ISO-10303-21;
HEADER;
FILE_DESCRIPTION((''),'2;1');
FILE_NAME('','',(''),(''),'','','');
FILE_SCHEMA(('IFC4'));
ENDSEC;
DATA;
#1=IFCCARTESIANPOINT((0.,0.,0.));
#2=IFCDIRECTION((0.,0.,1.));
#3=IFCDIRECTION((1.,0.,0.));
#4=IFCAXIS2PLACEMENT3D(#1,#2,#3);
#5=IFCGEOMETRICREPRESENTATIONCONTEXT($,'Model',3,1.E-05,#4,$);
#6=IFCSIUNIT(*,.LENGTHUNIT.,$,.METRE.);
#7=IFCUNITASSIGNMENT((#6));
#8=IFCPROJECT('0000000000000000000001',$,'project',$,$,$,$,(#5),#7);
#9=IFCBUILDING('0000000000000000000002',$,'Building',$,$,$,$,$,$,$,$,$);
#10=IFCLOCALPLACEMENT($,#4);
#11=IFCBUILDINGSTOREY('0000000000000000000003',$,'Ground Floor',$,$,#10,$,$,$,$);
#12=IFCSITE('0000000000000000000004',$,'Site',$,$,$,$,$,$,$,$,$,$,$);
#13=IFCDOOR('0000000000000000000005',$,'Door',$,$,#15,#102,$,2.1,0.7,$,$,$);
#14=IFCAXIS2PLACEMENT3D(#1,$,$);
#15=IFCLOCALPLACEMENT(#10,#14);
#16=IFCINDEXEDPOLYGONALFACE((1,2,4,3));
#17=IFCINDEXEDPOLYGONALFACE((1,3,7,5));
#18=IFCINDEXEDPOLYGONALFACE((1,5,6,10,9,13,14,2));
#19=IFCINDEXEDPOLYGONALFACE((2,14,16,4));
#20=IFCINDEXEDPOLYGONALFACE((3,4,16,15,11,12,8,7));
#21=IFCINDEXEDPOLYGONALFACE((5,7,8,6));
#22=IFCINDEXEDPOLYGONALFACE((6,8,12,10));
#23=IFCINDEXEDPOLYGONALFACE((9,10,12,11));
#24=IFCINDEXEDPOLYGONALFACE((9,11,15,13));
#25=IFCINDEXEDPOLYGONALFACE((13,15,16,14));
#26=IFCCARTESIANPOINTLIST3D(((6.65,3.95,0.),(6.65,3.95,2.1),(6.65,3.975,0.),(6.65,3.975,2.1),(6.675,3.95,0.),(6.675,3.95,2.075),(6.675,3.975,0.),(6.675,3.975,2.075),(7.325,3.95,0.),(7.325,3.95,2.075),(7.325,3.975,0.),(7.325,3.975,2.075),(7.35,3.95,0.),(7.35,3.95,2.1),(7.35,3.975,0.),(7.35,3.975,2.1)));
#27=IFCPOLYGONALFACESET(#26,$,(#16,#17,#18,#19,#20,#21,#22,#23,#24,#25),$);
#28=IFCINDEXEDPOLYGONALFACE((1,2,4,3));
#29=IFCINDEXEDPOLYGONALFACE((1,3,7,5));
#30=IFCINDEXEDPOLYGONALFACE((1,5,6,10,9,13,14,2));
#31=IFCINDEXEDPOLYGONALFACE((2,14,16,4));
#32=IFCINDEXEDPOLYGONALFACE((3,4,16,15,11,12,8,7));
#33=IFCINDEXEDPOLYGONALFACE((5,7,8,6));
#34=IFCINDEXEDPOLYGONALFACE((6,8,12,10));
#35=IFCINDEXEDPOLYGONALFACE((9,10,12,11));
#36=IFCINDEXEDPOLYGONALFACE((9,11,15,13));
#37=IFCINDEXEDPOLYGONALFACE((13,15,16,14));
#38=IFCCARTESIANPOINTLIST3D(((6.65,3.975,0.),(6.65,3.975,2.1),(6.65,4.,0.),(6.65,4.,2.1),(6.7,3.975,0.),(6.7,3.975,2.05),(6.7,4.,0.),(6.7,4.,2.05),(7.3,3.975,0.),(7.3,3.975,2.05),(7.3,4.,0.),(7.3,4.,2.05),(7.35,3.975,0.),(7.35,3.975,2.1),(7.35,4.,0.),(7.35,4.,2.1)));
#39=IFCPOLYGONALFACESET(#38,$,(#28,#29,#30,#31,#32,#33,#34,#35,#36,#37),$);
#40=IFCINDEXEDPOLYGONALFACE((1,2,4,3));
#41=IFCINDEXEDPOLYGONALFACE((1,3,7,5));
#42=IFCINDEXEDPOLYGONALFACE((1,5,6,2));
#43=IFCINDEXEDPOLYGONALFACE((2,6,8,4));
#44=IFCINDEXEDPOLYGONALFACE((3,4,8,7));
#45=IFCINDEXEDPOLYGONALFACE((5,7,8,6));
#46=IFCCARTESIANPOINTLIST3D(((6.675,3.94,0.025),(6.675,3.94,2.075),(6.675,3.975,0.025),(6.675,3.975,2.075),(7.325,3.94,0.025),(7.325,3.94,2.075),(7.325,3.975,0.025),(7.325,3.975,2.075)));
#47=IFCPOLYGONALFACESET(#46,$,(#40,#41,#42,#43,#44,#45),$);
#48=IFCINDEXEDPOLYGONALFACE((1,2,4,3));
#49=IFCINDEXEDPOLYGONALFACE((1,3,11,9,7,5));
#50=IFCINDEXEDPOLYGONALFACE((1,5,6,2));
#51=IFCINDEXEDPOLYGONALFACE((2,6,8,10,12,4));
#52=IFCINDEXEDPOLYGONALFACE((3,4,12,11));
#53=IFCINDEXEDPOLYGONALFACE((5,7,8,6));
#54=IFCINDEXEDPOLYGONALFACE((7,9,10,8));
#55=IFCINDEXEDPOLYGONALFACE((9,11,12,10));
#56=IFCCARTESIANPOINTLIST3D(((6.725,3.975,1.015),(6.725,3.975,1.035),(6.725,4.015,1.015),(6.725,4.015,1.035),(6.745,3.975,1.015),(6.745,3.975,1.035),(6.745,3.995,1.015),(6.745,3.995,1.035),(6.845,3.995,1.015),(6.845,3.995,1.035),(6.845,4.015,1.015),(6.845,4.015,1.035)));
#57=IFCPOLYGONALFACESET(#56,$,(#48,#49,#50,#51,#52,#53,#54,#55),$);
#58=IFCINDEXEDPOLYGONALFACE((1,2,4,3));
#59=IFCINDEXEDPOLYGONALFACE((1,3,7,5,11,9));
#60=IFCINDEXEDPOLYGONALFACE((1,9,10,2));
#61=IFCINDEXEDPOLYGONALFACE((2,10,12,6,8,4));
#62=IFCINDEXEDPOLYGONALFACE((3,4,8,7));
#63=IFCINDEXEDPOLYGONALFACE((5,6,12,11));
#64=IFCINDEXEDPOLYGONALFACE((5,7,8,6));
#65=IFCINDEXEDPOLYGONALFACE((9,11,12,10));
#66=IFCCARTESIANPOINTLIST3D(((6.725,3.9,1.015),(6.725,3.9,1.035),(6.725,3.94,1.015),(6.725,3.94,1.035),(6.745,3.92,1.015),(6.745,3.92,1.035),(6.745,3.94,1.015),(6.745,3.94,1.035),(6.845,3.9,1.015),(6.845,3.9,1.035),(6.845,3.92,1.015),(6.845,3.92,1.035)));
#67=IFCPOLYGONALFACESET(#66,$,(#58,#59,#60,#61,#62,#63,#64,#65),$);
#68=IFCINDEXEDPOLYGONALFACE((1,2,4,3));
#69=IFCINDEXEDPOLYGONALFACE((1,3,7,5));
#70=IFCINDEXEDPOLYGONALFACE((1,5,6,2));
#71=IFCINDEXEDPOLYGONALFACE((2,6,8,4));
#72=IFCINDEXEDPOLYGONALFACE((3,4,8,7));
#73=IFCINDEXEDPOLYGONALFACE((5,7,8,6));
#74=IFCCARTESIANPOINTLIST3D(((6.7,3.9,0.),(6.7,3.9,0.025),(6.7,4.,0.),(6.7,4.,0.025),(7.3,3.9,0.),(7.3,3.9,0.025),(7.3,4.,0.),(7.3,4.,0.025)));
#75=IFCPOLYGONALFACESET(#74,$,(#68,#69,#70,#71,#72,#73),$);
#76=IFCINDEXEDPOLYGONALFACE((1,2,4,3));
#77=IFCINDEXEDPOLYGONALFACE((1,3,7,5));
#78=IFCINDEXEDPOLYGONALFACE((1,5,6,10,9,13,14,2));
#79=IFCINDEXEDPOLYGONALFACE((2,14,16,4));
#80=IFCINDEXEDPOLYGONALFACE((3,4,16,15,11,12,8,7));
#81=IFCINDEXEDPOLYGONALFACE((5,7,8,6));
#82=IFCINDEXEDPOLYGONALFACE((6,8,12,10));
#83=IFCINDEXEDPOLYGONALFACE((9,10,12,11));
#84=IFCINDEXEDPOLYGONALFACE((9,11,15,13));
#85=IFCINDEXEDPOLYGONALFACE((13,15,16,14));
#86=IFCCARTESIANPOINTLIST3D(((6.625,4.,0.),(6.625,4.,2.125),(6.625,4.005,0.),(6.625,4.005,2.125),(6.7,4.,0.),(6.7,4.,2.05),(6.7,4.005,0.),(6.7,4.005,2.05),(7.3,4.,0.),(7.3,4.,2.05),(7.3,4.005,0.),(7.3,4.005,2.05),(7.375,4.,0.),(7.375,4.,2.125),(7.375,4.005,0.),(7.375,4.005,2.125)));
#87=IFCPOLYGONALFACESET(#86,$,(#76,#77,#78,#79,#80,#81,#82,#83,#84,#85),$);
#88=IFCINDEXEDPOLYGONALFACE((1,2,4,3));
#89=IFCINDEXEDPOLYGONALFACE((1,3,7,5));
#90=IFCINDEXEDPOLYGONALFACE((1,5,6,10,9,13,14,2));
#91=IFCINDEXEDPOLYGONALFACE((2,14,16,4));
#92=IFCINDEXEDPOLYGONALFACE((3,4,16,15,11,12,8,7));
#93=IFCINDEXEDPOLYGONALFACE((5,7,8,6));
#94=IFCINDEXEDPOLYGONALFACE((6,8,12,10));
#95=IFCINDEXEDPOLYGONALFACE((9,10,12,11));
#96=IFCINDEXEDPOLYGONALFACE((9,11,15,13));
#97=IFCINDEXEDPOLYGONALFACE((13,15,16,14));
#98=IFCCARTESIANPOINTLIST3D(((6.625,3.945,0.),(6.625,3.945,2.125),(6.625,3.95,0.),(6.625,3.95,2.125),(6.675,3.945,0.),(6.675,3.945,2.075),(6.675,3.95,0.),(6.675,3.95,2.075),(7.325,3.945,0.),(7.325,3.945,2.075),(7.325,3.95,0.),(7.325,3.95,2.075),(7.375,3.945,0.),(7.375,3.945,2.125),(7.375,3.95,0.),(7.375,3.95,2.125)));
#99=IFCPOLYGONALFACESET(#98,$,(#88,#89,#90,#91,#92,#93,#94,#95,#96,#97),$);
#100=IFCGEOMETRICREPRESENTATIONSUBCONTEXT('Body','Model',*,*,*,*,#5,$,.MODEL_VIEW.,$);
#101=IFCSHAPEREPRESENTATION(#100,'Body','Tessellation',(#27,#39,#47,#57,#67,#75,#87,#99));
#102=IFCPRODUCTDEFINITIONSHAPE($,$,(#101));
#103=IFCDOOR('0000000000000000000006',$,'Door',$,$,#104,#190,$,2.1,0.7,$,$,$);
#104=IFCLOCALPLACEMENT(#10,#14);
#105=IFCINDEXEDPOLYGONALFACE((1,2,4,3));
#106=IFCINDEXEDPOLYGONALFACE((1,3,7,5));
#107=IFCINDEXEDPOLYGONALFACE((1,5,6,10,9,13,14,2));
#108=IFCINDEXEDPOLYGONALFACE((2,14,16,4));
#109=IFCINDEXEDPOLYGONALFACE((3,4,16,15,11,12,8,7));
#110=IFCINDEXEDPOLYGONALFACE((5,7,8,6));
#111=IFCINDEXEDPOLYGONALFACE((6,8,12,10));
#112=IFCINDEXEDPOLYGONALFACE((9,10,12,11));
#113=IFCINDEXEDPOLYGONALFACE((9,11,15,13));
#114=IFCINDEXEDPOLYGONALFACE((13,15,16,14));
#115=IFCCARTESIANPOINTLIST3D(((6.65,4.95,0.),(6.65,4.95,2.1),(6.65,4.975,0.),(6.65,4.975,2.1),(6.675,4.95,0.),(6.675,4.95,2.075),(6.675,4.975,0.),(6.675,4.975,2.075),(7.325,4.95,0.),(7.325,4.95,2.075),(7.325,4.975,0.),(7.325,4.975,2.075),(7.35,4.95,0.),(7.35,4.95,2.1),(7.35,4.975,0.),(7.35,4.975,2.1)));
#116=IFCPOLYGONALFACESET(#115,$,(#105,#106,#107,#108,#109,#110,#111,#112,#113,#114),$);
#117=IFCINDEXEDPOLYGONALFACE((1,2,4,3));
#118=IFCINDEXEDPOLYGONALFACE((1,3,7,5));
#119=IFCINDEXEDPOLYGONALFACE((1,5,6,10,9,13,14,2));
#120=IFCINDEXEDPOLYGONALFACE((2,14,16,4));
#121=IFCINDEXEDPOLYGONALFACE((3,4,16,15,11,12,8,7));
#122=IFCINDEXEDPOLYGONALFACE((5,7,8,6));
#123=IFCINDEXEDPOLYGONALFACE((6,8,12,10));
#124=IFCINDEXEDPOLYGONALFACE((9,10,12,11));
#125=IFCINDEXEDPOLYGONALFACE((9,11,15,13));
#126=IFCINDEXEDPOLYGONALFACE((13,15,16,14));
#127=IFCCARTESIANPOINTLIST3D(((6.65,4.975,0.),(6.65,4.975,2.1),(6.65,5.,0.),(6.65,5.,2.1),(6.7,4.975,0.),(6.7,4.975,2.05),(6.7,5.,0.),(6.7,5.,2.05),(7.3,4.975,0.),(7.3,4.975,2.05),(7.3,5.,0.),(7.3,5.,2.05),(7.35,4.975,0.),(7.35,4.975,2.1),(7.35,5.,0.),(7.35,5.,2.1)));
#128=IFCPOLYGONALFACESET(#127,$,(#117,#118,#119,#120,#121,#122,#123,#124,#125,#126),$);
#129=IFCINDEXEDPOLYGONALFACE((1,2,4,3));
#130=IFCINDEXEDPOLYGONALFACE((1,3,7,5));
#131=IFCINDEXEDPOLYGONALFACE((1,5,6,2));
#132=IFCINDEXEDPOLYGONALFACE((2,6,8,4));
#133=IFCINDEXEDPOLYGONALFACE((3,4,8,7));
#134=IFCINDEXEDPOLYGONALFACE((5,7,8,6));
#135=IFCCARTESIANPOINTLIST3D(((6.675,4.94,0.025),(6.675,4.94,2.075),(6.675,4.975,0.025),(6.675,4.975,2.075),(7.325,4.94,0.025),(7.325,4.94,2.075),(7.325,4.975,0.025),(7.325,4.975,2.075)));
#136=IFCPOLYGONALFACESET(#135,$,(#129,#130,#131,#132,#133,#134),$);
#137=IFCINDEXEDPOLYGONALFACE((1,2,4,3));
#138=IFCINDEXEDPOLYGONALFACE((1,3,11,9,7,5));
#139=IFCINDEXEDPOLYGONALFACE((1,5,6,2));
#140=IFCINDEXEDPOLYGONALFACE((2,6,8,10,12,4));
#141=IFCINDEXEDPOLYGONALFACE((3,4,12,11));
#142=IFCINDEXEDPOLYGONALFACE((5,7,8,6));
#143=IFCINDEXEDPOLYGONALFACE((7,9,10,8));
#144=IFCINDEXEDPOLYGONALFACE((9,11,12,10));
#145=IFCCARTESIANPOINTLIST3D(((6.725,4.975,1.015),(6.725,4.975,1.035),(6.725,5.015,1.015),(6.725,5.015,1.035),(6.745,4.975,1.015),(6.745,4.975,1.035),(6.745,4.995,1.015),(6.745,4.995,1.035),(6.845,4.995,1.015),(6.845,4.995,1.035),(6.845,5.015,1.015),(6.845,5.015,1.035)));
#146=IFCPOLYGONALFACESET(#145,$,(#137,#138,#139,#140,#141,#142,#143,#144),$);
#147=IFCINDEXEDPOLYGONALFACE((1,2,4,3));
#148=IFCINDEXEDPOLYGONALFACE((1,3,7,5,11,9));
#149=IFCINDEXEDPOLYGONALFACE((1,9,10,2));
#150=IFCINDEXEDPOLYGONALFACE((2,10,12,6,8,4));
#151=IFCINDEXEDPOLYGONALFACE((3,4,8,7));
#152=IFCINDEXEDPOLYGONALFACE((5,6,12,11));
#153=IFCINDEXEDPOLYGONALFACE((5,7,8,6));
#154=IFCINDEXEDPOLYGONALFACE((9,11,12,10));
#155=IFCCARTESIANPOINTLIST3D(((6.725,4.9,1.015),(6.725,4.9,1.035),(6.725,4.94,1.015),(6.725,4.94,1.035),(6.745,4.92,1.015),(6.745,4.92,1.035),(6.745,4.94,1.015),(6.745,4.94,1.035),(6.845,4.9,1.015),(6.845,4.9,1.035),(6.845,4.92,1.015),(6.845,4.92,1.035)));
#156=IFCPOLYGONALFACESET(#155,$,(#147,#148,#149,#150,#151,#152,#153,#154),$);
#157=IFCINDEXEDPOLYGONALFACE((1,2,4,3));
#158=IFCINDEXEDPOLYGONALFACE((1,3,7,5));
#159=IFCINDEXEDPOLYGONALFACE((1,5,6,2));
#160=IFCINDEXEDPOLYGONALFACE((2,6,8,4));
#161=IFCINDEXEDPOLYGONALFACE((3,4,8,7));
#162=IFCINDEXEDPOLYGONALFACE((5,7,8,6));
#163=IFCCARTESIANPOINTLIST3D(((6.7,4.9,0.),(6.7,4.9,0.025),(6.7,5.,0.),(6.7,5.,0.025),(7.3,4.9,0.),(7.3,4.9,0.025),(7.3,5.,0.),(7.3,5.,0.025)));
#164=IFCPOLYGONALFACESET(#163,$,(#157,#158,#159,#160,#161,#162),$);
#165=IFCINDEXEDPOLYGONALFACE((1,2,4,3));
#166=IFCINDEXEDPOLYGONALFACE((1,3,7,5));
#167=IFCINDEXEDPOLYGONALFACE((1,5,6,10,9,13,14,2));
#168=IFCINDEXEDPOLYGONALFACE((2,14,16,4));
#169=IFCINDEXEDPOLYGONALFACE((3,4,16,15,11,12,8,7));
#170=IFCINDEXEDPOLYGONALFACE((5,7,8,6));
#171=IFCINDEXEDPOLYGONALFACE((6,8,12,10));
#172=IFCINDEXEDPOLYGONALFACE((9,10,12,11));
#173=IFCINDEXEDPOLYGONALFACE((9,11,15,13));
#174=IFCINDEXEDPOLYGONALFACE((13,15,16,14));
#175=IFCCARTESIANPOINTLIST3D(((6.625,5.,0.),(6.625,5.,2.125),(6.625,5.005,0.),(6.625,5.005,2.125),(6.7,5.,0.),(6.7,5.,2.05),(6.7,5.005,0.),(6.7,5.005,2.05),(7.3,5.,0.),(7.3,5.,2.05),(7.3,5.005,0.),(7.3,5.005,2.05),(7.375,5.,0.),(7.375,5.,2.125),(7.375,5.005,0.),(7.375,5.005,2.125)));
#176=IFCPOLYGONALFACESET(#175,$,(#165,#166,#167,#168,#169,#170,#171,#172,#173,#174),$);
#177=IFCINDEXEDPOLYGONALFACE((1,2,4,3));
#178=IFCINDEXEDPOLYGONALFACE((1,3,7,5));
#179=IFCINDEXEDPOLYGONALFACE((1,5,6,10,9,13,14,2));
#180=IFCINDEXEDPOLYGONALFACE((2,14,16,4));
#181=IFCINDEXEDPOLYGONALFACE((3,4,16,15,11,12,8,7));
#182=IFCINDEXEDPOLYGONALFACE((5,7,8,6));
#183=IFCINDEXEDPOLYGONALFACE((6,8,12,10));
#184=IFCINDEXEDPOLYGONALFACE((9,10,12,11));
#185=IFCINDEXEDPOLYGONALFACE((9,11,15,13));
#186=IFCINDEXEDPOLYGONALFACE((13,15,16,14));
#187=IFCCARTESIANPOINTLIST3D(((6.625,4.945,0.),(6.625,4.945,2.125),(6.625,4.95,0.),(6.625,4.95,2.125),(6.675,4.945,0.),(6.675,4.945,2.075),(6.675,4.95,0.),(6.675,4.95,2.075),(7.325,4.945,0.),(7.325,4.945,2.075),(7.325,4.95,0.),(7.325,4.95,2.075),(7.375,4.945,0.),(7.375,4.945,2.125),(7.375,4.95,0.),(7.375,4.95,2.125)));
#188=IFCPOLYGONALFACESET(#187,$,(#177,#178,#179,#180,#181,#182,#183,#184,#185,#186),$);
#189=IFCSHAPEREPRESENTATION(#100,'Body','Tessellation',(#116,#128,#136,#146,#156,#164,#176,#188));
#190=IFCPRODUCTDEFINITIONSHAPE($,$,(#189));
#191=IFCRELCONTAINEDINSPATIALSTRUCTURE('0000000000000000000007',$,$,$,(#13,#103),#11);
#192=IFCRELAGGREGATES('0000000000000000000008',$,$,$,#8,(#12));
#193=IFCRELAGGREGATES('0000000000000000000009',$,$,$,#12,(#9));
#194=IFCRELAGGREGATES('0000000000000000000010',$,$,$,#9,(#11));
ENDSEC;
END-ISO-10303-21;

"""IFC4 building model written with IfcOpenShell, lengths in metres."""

from ifc_helpers import new_model, si_unit, frame, origin_with_axes, place, context, subcontext, project, spatial, line, indexed_curve, outline, extrude, element, save


model = new_model("IFC4")

# Units and contexts
model_context = context("Model", 3, precision=1e-05, world=origin_with_axes())
body_context = subcontext(model_context, "Body", "Model", "MODEL_VIEW")
ifc_project = project(units=[si_unit("LENGTHUNIT", "METRE")], contexts=[model_context])

# Site, building, storey
site = spatial("IfcSite", under=ifc_project, Name="Site")
building = spatial("IfcBuilding", under=site, Name="Building")
storey_placement = place(None, origin_with_axes())
storey = spatial("IfcBuildingStorey", under=building, at=storey_placement, Name="Ground Floor")

# Doors
door_1_placement = place(storey_placement, frame((7.35, 4.0, 0.0), z_axis=(0.0, 0.0, 1.0), x_axis=(-1.0, 0.0, 0.0)))
element("IfcDoor", 1, at=door_1_placement, inside=storey, Name="Door", OverallHeight=2.1, OverallWidth=0.7, context=body_context, shape_type="SweptSolid", body=[
    extrude(outline(indexed_curve([(0.0, 0.0), (0.0, 2.1), (0.7, 2.1), (0.7, 0.0), (0.675, 0.0), (0.675, 2.075), (0.025, 2.075), (0.025, 0.0)], segments=[line(1, 2, 3, 4, 5, 6, 7, 8, 1)])), frame((0.0, 0.025, 0.0), z_axis=(0.0, -1.0, 0.0), x_axis=(1.0, 0.0, 0.0)), (0.0, 0.0, -1.0), 0.025),
    extrude(outline(indexed_curve([(0.0, 0.0), (0.0, 2.1), (0.7, 2.1), (0.7, 0.0), (0.65, 0.0), (0.65, 2.05), (0.05, 2.05), (0.05, 0.0)], segments=[line(1, 2, 3, 4, 5, 6, 7, 8, 1)])), frame((0.0, 0.0, 0.0), z_axis=(0.0, -1.0, 0.0), x_axis=(1.0, 0.0, 0.0)), (0.0, 0.0, -1.0), 0.025),
    extrude(outline(indexed_curve([(0.0, 0.0), (0.65, 0.0), (0.65, 0.035), (0.0, 0.035)], segments=[line(1, 2, 3, 4, 1)])), frame((0.025, 0.025, 0.025), z_axis=(0.0, 0.0, 1.0), x_axis=(1.0, 0.0, 0.0)), (0.0, 0.0, 1.0), 2.05),
    extrude(outline(indexed_curve([(0.0, 0.0), (0.0, -0.04), (-0.12, -0.04), (-0.12, -0.02), (-0.02, -0.02), (-0.02, 0.0)], segments=[line(1, 2, 3, 4, 5, 6, 1)])), frame((0.625, 0.025, 1.015), z_axis=(0.0, 0.0, 1.0), x_axis=(1.0, 0.0, 0.0)), (0.0, 0.0, 1.0), 0.02),
    extrude(outline(indexed_curve([(0.0, 0.0), (0.0, 0.04), (-0.12, 0.04), (-0.12, 0.02), (-0.02, 0.02), (-0.02, 0.0)], segments=[line(1, 2, 3, 4, 5, 6, 1)])), frame((0.625, 0.06, 1.015), z_axis=(0.0, 0.0, 1.0), x_axis=(1.0, 0.0, 0.0)), (0.0, 0.0, 1.0), 0.02),
    extrude(outline(indexed_curve([(0.0, 0.0), (0.6, 0.0), (0.6, 0.1), (0.0, 0.1)], segments=[line(1, 2, 3, 4, 1)])), frame((0.05, 0.0, 0.0), z_axis=(0.0, 0.0, 1.0), x_axis=(1.0, 0.0, 0.0)), (0.0, 0.0, 1.0), 0.025),
    extrude(outline(indexed_curve([(0.0, 0.0), (0.0, 2.125), (0.75, 2.125), (0.75, 0.0), (0.675, 0.0), (0.675, 2.05), (0.075, 2.05), (0.075, 0.0)], segments=[line(1, 2, 3, 4, 5, 6, 7, 8, 1)])), frame((-0.025, -0.005, 0.0), z_axis=(0.0, -1.0, 0.0), x_axis=(1.0, 0.0, 0.0)), (0.0, 0.0, -1.0), 0.005),
    extrude(outline(indexed_curve([(0.0, 0.0), (0.0, 2.125), (0.75, 2.125), (0.75, 0.0), (0.7, 0.0), (0.7, 2.075), (0.05, 2.075), (0.05, 0.0)], segments=[line(1, 2, 3, 4, 5, 6, 7, 8, 1)])), frame((-0.025, 0.05, 0.0), z_axis=(0.0, -1.0, 0.0), x_axis=(1.0, 0.0, 0.0)), (0.0, 0.0, -1.0), 0.005),
])
door_2_placement = place(storey_placement, frame((7.35, 5.0, 0.0), z_axis=(0.0, 0.0, 1.0), x_axis=(-1.0, 0.0, 0.0)))
element("IfcDoor", 2, at=door_2_placement, inside=storey, Name="Door", OverallHeight=2.1, OverallWidth=0.7, context=body_context, shape_type="SweptSolid", body=[
    extrude(outline(indexed_curve([(0.0, 0.0), (0.0, 2.1), (0.7, 2.1), (0.7, 0.0), (0.675, 0.0), (0.675, 2.075), (0.025, 2.075), (0.025, 0.0)], segments=[line(1, 2, 3, 4, 5, 6, 7, 8, 1)])), frame((0.0, 0.025, 0.0), z_axis=(0.0, -1.0, 0.0), x_axis=(1.0, 0.0, 0.0)), (0.0, 0.0, -1.0), 0.025),
    extrude(outline(indexed_curve([(0.0, 0.0), (0.0, 2.1), (0.7, 2.1), (0.7, 0.0), (0.65, 0.0), (0.65, 2.05), (0.05, 2.05), (0.05, 0.0)], segments=[line(1, 2, 3, 4, 5, 6, 7, 8, 1)])), frame((0.0, 0.0, 0.0), z_axis=(0.0, -1.0, 0.0), x_axis=(1.0, 0.0, 0.0)), (0.0, 0.0, -1.0), 0.025),
    extrude(outline(indexed_curve([(0.0, 0.0), (0.65, 0.0), (0.65, 0.035), (0.0, 0.035)], segments=[line(1, 2, 3, 4, 1)])), frame((0.025, 0.025, 0.025), z_axis=(0.0, 0.0, 1.0), x_axis=(1.0, 0.0, 0.0)), (0.0, 0.0, 1.0), 2.05),
    extrude(outline(indexed_curve([(0.0, 0.0), (0.0, -0.04), (-0.12, -0.04), (-0.12, -0.02), (-0.02, -0.02), (-0.02, 0.0)], segments=[line(1, 2, 3, 4, 5, 6, 1)])), frame((0.625, 0.025, 1.015), z_axis=(0.0, 0.0, 1.0), x_axis=(1.0, 0.0, 0.0)), (0.0, 0.0, 1.0), 0.02),
    extrude(outline(indexed_curve([(0.0, 0.0), (0.0, 0.04), (-0.12, 0.04), (-0.12, 0.02), (-0.02, 0.02), (-0.02, 0.0)], segments=[line(1, 2, 3, 4, 5, 6, 1)])), frame((0.625, 0.06, 1.015), z_axis=(0.0, 0.0, 1.0), x_axis=(1.0, 0.0, 0.0)), (0.0, 0.0, 1.0), 0.02),
    extrude(outline(indexed_curve([(0.0, 0.0), (0.6, 0.0), (0.6, 0.1), (0.0, 0.1)], segments=[line(1, 2, 3, 4, 1)])), frame((0.05, 0.0, 0.0), z_axis=(0.0, 0.0, 1.0), x_axis=(1.0, 0.0, 0.0)), (0.0, 0.0, 1.0), 0.025),
    extrude(outline(indexed_curve([(0.0, 0.0), (0.0, 2.125), (0.75, 2.125), (0.75, 0.0), (0.675, 0.0), (0.675, 2.05), (0.075, 2.05), (0.075, 0.0)], segments=[line(1, 2, 3, 4, 5, 6, 7, 8, 1)])), frame((-0.025, -0.005, 0.0), z_axis=(0.0, -1.0, 0.0), x_axis=(1.0, 0.0, 0.0)), (0.0, 0.0, -1.0), 0.005),
    extrude(outline(indexed_curve([(0.0, 0.0), (0.0, 2.125), (0.75, 2.125), (0.75, 0.0), (0.7, 0.0), (0.7, 2.075), (0.05, 2.075), (0.05, 0.0)], segments=[line(1, 2, 3, 4, 5, 6, 7, 8, 1)])), frame((-0.025, 0.05, 0.0), z_axis=(0.0, -1.0, 0.0), x_axis=(1.0, 0.0, 0.0)), (0.0, 0.0, -1.0), 0.005),
])

save(model, "model.ifc")
